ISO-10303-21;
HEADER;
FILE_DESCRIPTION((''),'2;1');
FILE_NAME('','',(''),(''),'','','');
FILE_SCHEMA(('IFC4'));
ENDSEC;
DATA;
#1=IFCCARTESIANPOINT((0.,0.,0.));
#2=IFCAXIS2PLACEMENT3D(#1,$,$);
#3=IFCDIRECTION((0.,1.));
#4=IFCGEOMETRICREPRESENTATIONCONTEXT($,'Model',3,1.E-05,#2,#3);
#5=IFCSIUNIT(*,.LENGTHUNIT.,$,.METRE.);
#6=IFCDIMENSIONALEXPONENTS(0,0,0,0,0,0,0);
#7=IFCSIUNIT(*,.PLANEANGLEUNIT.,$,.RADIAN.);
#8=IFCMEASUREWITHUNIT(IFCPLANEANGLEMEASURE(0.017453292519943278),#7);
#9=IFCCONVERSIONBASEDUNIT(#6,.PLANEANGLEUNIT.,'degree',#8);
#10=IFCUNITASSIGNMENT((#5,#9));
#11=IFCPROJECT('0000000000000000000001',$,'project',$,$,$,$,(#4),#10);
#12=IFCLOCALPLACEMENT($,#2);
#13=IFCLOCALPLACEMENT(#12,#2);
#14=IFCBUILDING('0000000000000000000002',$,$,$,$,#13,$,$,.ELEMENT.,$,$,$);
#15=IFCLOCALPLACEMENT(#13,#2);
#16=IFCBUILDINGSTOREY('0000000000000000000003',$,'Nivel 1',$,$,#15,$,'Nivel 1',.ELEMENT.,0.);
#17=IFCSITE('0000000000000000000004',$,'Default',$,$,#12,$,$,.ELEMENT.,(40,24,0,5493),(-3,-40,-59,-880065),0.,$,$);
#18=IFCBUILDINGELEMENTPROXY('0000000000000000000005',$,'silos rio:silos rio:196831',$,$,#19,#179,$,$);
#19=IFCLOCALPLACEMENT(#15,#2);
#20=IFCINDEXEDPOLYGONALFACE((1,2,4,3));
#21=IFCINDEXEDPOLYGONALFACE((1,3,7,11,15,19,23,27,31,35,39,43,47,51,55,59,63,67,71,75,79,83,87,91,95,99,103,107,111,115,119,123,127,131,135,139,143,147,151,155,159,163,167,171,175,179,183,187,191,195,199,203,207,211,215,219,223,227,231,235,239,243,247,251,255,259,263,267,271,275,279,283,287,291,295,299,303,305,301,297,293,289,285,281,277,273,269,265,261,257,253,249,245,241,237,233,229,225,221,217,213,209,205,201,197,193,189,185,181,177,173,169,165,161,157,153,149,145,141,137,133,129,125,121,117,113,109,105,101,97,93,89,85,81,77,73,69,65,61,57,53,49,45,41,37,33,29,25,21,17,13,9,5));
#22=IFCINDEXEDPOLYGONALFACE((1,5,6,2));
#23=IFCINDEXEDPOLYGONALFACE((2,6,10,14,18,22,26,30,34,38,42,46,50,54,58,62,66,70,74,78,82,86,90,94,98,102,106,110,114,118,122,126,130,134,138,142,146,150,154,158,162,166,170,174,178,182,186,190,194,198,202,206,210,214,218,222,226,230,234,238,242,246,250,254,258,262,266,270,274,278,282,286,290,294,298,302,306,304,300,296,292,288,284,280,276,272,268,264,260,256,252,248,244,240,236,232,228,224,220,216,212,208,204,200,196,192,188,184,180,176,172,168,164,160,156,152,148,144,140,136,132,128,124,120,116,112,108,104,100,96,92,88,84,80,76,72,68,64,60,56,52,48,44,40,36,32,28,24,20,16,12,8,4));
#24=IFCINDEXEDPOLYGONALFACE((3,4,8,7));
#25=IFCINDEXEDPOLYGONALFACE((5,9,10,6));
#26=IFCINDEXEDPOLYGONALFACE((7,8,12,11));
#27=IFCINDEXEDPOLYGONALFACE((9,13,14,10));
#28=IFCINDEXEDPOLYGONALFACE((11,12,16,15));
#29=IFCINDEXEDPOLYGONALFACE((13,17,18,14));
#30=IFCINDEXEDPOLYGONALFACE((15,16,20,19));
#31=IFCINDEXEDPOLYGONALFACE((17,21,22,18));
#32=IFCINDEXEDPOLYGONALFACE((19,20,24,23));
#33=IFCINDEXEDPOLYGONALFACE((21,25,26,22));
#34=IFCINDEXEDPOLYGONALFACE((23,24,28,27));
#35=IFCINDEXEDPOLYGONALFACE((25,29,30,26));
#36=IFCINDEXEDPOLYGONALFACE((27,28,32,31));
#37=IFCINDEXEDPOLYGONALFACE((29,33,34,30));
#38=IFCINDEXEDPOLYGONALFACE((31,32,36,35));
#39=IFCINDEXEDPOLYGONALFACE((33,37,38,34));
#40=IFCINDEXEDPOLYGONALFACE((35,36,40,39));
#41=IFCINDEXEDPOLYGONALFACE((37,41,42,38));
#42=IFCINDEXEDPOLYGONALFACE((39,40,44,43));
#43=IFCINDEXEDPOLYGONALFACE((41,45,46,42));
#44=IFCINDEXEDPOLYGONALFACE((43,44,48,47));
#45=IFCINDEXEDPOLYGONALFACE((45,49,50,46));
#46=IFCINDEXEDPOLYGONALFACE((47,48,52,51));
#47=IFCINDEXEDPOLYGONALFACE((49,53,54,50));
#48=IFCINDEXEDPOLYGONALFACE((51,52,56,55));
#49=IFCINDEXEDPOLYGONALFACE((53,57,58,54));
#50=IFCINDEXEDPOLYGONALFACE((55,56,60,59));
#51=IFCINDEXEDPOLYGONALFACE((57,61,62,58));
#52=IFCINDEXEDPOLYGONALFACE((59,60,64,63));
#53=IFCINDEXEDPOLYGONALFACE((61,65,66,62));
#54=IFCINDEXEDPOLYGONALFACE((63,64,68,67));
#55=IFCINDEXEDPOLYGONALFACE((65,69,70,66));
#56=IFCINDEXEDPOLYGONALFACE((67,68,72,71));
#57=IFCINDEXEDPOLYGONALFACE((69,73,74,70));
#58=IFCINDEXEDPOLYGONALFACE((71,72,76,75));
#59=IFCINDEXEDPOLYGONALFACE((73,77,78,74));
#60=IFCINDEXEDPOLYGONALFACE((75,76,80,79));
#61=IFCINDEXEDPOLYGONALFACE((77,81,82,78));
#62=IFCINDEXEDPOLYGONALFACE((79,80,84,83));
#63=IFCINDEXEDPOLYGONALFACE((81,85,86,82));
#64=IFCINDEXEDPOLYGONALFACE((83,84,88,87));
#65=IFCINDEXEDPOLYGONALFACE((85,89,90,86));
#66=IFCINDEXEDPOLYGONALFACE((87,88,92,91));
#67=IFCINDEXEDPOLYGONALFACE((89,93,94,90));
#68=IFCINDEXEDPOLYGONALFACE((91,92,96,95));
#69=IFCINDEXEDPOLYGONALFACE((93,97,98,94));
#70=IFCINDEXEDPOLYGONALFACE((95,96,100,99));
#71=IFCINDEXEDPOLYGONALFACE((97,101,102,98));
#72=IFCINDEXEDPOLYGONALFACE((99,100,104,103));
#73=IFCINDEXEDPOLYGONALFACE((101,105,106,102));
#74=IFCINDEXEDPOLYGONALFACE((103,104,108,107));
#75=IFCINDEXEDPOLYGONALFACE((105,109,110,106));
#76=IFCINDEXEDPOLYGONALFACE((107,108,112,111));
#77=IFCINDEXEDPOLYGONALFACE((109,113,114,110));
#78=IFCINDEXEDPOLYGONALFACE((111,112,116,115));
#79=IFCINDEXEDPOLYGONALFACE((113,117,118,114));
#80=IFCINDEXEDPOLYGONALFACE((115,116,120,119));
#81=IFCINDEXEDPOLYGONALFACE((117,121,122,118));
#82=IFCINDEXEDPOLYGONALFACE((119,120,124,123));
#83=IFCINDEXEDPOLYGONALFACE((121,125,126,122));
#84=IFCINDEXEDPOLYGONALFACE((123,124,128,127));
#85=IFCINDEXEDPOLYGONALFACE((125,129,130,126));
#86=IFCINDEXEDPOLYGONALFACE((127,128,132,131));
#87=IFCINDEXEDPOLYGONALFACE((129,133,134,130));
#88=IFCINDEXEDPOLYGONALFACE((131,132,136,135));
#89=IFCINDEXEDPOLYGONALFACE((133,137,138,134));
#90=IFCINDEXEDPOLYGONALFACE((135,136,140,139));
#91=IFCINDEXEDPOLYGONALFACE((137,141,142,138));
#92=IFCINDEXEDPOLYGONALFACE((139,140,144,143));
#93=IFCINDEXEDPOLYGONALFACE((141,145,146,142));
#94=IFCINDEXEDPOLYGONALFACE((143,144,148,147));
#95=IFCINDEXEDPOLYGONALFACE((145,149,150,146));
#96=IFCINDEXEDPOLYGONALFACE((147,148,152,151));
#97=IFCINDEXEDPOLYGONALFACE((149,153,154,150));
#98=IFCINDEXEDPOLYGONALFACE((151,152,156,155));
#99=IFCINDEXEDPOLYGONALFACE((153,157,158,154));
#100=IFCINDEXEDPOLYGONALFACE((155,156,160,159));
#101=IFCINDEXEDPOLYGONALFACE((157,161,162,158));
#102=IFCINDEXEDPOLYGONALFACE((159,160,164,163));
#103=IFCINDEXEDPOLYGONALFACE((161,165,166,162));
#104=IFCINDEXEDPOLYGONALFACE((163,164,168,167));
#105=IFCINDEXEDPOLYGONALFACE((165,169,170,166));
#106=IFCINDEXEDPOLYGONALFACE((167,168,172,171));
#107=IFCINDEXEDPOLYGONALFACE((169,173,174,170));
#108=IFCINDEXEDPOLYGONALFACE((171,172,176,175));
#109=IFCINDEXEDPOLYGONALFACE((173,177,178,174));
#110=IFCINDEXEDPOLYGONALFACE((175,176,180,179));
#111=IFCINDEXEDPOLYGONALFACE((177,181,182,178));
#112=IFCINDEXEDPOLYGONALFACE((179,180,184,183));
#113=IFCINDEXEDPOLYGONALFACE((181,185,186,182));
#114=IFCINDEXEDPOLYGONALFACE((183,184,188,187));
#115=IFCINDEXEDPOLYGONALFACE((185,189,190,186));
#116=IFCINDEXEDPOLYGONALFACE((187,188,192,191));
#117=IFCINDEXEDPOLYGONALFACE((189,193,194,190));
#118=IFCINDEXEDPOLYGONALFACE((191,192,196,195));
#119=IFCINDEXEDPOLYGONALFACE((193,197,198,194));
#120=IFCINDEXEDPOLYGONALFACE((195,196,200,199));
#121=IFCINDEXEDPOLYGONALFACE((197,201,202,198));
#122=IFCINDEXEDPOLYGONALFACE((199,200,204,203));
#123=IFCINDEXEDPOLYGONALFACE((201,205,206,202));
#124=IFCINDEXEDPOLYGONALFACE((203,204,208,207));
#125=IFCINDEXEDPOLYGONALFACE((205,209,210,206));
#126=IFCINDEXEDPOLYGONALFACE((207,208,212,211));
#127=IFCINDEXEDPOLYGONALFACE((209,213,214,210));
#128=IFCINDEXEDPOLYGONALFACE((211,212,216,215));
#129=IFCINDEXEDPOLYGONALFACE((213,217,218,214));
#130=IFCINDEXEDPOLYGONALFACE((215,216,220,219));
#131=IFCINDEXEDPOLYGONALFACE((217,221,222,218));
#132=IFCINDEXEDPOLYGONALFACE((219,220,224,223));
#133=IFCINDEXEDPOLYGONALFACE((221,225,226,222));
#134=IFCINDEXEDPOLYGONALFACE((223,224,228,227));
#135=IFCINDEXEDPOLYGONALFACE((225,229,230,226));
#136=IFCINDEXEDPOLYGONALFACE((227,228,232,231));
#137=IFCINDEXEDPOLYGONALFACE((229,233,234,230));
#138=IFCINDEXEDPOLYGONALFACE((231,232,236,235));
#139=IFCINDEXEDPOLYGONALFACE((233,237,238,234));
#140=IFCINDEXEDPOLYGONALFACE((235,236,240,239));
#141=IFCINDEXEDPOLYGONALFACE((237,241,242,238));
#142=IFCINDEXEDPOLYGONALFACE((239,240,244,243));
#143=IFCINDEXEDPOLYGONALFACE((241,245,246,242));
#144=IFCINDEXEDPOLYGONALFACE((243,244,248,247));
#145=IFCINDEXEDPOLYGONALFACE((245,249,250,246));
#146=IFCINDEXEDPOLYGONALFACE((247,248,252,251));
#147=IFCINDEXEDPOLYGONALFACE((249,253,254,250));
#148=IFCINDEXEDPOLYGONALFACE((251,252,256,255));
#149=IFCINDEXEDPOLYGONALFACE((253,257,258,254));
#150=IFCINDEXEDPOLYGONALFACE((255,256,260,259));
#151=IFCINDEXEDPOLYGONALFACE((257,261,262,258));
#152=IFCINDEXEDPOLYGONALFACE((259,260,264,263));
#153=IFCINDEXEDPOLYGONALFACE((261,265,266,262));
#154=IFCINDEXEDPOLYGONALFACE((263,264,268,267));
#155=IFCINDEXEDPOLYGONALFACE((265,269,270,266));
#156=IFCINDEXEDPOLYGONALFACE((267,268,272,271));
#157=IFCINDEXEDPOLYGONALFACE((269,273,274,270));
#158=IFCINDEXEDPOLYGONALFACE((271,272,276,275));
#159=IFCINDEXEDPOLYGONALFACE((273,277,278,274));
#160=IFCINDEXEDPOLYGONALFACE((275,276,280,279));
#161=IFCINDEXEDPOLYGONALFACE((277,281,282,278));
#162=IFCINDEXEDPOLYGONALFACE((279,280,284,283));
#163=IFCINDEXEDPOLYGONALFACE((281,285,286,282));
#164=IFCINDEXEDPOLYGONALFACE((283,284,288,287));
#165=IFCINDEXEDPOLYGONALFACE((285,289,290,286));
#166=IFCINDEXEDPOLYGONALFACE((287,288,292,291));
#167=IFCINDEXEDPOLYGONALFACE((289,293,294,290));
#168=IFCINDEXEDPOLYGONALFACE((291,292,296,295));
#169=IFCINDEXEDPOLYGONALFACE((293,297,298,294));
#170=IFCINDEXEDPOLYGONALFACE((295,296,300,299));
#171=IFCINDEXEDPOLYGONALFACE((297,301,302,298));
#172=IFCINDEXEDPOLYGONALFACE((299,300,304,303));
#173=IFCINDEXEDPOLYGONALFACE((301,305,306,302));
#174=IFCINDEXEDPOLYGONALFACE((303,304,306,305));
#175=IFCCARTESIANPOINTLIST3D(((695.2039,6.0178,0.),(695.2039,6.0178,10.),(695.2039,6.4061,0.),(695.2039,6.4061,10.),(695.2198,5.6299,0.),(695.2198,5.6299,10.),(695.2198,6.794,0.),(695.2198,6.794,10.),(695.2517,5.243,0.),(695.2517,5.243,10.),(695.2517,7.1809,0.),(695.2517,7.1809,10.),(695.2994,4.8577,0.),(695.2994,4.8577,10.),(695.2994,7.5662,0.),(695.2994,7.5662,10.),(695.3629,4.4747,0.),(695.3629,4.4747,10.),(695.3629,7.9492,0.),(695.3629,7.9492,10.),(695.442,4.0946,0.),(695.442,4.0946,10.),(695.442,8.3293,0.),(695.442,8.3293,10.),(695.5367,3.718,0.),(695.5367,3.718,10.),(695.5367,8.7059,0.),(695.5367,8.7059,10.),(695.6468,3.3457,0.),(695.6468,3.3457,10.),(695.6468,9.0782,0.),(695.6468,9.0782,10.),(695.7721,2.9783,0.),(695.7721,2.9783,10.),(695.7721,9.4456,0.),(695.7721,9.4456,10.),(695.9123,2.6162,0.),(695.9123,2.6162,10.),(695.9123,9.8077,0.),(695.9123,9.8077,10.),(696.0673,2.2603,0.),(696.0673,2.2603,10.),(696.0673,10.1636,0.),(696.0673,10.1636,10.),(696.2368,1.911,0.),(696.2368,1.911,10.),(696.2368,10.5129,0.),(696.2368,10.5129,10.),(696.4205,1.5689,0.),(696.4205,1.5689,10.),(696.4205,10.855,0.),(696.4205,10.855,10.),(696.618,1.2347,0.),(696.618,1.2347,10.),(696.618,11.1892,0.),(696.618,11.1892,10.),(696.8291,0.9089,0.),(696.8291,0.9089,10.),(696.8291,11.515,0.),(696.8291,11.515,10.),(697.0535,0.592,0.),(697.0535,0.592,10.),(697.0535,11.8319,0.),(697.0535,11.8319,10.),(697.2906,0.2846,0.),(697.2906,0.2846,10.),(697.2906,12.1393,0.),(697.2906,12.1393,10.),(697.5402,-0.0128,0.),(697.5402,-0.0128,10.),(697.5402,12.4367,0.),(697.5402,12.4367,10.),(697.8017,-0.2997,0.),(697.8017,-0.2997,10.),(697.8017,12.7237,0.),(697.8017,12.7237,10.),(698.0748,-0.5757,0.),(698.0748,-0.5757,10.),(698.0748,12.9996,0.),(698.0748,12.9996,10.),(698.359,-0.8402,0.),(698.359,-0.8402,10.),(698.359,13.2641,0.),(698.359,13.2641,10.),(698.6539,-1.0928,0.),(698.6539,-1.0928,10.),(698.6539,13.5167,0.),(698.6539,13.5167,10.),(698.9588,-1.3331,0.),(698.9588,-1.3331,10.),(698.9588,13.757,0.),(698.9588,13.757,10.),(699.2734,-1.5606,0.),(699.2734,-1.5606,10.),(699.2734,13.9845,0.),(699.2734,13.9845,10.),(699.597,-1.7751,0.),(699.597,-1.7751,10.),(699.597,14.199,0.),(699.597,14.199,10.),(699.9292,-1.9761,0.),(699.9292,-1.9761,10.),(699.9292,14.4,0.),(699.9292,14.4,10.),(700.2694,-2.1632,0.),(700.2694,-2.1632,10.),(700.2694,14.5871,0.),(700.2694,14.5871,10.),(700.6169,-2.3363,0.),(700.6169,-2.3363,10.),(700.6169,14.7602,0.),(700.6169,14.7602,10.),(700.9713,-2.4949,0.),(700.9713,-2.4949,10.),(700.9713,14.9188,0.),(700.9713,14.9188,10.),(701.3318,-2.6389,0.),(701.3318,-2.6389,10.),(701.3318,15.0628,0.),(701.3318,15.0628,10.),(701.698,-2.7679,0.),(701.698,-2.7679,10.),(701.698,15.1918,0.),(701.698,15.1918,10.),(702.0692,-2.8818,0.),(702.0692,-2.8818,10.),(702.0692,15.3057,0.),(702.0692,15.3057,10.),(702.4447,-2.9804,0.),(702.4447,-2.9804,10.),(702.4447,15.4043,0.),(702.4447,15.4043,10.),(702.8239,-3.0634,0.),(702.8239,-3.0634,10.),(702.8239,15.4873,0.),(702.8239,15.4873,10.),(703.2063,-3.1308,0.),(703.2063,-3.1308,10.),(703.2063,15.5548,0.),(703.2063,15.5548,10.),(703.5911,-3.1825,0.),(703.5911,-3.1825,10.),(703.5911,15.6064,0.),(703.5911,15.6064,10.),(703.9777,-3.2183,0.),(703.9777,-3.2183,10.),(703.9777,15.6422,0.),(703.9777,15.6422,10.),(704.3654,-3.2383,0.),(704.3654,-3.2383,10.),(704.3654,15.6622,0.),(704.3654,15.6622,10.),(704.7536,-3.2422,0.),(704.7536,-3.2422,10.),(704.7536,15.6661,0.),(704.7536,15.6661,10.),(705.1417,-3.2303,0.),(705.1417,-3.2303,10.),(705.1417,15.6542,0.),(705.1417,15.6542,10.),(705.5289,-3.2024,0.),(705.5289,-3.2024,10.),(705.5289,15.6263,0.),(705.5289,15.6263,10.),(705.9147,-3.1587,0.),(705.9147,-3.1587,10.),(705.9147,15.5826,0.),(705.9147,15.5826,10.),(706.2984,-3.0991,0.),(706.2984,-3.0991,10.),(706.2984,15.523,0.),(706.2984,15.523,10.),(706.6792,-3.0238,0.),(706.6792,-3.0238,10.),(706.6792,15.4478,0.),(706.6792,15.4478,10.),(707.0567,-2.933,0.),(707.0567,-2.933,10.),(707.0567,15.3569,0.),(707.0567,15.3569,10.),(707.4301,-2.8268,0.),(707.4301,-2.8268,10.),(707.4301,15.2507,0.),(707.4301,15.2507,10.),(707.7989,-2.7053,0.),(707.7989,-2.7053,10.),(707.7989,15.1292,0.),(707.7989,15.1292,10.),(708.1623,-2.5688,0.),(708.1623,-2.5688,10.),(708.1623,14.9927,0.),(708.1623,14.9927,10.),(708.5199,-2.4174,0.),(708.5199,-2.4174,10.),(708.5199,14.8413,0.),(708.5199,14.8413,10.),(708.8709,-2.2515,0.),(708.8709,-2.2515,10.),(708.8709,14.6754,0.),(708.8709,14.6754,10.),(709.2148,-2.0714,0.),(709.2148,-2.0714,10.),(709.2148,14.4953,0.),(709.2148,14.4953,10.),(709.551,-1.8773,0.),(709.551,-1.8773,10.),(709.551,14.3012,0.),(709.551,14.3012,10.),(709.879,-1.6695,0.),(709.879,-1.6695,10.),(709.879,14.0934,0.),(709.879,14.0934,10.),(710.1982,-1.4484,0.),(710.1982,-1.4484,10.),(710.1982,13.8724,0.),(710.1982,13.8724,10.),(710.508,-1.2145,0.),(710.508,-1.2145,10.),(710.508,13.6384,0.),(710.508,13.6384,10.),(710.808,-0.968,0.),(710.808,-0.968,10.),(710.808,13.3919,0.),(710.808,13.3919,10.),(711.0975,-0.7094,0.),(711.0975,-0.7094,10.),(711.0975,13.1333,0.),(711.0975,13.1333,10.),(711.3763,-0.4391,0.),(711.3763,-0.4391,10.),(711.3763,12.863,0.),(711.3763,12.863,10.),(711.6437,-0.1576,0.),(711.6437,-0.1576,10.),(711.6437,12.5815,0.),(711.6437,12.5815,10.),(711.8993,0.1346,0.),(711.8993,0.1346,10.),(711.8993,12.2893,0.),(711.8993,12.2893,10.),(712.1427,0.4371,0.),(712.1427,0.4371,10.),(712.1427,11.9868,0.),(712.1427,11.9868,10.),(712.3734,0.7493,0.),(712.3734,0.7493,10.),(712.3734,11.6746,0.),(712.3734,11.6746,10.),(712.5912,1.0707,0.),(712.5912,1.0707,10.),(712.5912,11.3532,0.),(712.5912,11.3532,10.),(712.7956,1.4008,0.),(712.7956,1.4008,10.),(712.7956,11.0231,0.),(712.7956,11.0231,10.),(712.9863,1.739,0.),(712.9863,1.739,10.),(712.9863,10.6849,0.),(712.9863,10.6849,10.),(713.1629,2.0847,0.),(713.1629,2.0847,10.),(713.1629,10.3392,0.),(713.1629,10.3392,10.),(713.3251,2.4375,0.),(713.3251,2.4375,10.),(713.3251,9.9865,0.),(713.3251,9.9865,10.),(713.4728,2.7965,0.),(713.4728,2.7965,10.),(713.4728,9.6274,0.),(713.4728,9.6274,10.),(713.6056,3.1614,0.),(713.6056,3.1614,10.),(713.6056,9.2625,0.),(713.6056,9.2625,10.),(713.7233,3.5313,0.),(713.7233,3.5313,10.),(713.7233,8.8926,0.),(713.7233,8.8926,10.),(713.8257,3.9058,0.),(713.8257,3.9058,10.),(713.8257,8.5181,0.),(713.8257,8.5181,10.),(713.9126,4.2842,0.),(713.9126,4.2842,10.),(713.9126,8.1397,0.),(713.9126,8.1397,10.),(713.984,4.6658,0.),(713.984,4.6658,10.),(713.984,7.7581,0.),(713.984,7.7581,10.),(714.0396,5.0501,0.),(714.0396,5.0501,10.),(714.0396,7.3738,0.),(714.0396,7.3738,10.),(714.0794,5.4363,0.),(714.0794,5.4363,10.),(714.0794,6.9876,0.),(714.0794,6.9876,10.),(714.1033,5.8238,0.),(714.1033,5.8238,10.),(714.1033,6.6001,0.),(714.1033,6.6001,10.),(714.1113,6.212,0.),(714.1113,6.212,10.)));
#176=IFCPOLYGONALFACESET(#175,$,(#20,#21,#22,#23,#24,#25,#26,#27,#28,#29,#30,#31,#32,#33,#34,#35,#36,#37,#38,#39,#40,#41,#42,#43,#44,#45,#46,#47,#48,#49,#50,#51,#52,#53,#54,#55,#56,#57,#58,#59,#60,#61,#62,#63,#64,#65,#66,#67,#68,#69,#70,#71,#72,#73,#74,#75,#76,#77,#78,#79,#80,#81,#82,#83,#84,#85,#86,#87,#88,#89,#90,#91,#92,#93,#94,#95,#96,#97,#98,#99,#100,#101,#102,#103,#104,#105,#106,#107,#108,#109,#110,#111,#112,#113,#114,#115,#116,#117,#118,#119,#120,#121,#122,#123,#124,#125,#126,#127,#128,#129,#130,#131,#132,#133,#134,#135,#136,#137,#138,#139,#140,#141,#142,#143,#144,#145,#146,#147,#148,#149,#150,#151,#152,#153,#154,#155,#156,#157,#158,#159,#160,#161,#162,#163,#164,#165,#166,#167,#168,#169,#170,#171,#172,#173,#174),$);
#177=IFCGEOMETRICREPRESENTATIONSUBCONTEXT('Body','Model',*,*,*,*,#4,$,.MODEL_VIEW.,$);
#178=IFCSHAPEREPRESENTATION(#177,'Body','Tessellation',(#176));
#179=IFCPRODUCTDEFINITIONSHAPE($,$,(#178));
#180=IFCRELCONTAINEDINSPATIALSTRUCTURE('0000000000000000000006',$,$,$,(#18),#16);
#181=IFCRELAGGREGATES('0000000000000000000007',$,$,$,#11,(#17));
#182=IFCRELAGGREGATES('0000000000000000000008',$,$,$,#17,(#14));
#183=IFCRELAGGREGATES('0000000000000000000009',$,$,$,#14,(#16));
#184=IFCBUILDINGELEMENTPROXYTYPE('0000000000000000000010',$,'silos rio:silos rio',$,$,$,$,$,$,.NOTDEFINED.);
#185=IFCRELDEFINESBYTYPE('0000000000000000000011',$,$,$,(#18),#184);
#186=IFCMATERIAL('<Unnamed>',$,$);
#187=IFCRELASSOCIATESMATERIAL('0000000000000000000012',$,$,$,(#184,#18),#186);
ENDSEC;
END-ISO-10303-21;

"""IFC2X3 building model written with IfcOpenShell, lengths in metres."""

from ifc_helpers import new_model, entity, si_unit, converted_unit, direction, frame, frame_2d, origin, place, context, subcontext, project, spatial, circle, extrude, source, transform, mapped, material, type_object, type_shapes, element, save


model = new_model("IFC2X3")

# Units and contexts
model_context = context("Model", 3, precision=1e-05, world=origin(), true_north=direction((0.0, 1.0)))
body_context = subcontext(model_context, "Body", "Model", "MODEL_VIEW")
ifc_project = project(units=[si_unit("LENGTHUNIT", "METRE"), converted_unit("PLANEANGLEUNIT", "degree", entity("IfcPlaneAngleMeasure", 0.017453292519943278), si_unit("PLANEANGLEUNIT", "RADIAN"), dimensions=[0, 0, 0, 0, 0, 0, 0])], contexts=[model_context])

# Site, building, storey
site_placement = place(None, origin())
site = spatial("IfcSite", under=ifc_project, at=site_placement, Name="Default", CompositionType="ELEMENT", RefLatitude=(40, 24, 0, 5493), RefLongitude=(-3, -40, -59, -880065), RefElevation=0.0)
building_placement = place(site_placement, origin())
building = spatial("IfcBuilding", under=site, at=building_placement, CompositionType="ELEMENT")
storey_placement = place(building_placement, origin())
storey = spatial("IfcBuildingStorey", under=building, at=storey_placement, Name="Nivel 1", LongName="Nivel 1", CompositionType="ELEMENT", Elevation=0.0)

# Building element proxy
ifc_material_1 = material(Name="<Unnamed>")
building_element_proxy_type_1 = type_object("IfcBuildingElementProxyType", Name="silos rio:silos rio", PredefinedType="NOTDEFINED", material=ifc_material_1)
shared_shape_1 = source(origin(), body_context, "Body", "SweptSolid", [
    extrude(circle(Radius=9.4547, at=frame_2d((0.0, 0.0), x_axis=(1.0, 0.0))), frame((704.6566, 6.212, 0.0)), (0.0, 0.0, 1.0), 10.0),
])
type_shapes(building_element_proxy_type_1, [shared_shape_1])
proxy_1_placement = place(storey_placement, origin())
element("IfcBuildingElementProxy", 1, at=proxy_1_placement, inside=storey, type_object=building_element_proxy_type_1, material=ifc_material_1, Name="silos rio:silos rio:196831", context=body_context, shape_type="MappedRepresentation", body=[
    mapped(shared_shape_1, transform((0.0, 0.0, 0.0), scale=1.0)),
])

save(model, "model.ifc")
